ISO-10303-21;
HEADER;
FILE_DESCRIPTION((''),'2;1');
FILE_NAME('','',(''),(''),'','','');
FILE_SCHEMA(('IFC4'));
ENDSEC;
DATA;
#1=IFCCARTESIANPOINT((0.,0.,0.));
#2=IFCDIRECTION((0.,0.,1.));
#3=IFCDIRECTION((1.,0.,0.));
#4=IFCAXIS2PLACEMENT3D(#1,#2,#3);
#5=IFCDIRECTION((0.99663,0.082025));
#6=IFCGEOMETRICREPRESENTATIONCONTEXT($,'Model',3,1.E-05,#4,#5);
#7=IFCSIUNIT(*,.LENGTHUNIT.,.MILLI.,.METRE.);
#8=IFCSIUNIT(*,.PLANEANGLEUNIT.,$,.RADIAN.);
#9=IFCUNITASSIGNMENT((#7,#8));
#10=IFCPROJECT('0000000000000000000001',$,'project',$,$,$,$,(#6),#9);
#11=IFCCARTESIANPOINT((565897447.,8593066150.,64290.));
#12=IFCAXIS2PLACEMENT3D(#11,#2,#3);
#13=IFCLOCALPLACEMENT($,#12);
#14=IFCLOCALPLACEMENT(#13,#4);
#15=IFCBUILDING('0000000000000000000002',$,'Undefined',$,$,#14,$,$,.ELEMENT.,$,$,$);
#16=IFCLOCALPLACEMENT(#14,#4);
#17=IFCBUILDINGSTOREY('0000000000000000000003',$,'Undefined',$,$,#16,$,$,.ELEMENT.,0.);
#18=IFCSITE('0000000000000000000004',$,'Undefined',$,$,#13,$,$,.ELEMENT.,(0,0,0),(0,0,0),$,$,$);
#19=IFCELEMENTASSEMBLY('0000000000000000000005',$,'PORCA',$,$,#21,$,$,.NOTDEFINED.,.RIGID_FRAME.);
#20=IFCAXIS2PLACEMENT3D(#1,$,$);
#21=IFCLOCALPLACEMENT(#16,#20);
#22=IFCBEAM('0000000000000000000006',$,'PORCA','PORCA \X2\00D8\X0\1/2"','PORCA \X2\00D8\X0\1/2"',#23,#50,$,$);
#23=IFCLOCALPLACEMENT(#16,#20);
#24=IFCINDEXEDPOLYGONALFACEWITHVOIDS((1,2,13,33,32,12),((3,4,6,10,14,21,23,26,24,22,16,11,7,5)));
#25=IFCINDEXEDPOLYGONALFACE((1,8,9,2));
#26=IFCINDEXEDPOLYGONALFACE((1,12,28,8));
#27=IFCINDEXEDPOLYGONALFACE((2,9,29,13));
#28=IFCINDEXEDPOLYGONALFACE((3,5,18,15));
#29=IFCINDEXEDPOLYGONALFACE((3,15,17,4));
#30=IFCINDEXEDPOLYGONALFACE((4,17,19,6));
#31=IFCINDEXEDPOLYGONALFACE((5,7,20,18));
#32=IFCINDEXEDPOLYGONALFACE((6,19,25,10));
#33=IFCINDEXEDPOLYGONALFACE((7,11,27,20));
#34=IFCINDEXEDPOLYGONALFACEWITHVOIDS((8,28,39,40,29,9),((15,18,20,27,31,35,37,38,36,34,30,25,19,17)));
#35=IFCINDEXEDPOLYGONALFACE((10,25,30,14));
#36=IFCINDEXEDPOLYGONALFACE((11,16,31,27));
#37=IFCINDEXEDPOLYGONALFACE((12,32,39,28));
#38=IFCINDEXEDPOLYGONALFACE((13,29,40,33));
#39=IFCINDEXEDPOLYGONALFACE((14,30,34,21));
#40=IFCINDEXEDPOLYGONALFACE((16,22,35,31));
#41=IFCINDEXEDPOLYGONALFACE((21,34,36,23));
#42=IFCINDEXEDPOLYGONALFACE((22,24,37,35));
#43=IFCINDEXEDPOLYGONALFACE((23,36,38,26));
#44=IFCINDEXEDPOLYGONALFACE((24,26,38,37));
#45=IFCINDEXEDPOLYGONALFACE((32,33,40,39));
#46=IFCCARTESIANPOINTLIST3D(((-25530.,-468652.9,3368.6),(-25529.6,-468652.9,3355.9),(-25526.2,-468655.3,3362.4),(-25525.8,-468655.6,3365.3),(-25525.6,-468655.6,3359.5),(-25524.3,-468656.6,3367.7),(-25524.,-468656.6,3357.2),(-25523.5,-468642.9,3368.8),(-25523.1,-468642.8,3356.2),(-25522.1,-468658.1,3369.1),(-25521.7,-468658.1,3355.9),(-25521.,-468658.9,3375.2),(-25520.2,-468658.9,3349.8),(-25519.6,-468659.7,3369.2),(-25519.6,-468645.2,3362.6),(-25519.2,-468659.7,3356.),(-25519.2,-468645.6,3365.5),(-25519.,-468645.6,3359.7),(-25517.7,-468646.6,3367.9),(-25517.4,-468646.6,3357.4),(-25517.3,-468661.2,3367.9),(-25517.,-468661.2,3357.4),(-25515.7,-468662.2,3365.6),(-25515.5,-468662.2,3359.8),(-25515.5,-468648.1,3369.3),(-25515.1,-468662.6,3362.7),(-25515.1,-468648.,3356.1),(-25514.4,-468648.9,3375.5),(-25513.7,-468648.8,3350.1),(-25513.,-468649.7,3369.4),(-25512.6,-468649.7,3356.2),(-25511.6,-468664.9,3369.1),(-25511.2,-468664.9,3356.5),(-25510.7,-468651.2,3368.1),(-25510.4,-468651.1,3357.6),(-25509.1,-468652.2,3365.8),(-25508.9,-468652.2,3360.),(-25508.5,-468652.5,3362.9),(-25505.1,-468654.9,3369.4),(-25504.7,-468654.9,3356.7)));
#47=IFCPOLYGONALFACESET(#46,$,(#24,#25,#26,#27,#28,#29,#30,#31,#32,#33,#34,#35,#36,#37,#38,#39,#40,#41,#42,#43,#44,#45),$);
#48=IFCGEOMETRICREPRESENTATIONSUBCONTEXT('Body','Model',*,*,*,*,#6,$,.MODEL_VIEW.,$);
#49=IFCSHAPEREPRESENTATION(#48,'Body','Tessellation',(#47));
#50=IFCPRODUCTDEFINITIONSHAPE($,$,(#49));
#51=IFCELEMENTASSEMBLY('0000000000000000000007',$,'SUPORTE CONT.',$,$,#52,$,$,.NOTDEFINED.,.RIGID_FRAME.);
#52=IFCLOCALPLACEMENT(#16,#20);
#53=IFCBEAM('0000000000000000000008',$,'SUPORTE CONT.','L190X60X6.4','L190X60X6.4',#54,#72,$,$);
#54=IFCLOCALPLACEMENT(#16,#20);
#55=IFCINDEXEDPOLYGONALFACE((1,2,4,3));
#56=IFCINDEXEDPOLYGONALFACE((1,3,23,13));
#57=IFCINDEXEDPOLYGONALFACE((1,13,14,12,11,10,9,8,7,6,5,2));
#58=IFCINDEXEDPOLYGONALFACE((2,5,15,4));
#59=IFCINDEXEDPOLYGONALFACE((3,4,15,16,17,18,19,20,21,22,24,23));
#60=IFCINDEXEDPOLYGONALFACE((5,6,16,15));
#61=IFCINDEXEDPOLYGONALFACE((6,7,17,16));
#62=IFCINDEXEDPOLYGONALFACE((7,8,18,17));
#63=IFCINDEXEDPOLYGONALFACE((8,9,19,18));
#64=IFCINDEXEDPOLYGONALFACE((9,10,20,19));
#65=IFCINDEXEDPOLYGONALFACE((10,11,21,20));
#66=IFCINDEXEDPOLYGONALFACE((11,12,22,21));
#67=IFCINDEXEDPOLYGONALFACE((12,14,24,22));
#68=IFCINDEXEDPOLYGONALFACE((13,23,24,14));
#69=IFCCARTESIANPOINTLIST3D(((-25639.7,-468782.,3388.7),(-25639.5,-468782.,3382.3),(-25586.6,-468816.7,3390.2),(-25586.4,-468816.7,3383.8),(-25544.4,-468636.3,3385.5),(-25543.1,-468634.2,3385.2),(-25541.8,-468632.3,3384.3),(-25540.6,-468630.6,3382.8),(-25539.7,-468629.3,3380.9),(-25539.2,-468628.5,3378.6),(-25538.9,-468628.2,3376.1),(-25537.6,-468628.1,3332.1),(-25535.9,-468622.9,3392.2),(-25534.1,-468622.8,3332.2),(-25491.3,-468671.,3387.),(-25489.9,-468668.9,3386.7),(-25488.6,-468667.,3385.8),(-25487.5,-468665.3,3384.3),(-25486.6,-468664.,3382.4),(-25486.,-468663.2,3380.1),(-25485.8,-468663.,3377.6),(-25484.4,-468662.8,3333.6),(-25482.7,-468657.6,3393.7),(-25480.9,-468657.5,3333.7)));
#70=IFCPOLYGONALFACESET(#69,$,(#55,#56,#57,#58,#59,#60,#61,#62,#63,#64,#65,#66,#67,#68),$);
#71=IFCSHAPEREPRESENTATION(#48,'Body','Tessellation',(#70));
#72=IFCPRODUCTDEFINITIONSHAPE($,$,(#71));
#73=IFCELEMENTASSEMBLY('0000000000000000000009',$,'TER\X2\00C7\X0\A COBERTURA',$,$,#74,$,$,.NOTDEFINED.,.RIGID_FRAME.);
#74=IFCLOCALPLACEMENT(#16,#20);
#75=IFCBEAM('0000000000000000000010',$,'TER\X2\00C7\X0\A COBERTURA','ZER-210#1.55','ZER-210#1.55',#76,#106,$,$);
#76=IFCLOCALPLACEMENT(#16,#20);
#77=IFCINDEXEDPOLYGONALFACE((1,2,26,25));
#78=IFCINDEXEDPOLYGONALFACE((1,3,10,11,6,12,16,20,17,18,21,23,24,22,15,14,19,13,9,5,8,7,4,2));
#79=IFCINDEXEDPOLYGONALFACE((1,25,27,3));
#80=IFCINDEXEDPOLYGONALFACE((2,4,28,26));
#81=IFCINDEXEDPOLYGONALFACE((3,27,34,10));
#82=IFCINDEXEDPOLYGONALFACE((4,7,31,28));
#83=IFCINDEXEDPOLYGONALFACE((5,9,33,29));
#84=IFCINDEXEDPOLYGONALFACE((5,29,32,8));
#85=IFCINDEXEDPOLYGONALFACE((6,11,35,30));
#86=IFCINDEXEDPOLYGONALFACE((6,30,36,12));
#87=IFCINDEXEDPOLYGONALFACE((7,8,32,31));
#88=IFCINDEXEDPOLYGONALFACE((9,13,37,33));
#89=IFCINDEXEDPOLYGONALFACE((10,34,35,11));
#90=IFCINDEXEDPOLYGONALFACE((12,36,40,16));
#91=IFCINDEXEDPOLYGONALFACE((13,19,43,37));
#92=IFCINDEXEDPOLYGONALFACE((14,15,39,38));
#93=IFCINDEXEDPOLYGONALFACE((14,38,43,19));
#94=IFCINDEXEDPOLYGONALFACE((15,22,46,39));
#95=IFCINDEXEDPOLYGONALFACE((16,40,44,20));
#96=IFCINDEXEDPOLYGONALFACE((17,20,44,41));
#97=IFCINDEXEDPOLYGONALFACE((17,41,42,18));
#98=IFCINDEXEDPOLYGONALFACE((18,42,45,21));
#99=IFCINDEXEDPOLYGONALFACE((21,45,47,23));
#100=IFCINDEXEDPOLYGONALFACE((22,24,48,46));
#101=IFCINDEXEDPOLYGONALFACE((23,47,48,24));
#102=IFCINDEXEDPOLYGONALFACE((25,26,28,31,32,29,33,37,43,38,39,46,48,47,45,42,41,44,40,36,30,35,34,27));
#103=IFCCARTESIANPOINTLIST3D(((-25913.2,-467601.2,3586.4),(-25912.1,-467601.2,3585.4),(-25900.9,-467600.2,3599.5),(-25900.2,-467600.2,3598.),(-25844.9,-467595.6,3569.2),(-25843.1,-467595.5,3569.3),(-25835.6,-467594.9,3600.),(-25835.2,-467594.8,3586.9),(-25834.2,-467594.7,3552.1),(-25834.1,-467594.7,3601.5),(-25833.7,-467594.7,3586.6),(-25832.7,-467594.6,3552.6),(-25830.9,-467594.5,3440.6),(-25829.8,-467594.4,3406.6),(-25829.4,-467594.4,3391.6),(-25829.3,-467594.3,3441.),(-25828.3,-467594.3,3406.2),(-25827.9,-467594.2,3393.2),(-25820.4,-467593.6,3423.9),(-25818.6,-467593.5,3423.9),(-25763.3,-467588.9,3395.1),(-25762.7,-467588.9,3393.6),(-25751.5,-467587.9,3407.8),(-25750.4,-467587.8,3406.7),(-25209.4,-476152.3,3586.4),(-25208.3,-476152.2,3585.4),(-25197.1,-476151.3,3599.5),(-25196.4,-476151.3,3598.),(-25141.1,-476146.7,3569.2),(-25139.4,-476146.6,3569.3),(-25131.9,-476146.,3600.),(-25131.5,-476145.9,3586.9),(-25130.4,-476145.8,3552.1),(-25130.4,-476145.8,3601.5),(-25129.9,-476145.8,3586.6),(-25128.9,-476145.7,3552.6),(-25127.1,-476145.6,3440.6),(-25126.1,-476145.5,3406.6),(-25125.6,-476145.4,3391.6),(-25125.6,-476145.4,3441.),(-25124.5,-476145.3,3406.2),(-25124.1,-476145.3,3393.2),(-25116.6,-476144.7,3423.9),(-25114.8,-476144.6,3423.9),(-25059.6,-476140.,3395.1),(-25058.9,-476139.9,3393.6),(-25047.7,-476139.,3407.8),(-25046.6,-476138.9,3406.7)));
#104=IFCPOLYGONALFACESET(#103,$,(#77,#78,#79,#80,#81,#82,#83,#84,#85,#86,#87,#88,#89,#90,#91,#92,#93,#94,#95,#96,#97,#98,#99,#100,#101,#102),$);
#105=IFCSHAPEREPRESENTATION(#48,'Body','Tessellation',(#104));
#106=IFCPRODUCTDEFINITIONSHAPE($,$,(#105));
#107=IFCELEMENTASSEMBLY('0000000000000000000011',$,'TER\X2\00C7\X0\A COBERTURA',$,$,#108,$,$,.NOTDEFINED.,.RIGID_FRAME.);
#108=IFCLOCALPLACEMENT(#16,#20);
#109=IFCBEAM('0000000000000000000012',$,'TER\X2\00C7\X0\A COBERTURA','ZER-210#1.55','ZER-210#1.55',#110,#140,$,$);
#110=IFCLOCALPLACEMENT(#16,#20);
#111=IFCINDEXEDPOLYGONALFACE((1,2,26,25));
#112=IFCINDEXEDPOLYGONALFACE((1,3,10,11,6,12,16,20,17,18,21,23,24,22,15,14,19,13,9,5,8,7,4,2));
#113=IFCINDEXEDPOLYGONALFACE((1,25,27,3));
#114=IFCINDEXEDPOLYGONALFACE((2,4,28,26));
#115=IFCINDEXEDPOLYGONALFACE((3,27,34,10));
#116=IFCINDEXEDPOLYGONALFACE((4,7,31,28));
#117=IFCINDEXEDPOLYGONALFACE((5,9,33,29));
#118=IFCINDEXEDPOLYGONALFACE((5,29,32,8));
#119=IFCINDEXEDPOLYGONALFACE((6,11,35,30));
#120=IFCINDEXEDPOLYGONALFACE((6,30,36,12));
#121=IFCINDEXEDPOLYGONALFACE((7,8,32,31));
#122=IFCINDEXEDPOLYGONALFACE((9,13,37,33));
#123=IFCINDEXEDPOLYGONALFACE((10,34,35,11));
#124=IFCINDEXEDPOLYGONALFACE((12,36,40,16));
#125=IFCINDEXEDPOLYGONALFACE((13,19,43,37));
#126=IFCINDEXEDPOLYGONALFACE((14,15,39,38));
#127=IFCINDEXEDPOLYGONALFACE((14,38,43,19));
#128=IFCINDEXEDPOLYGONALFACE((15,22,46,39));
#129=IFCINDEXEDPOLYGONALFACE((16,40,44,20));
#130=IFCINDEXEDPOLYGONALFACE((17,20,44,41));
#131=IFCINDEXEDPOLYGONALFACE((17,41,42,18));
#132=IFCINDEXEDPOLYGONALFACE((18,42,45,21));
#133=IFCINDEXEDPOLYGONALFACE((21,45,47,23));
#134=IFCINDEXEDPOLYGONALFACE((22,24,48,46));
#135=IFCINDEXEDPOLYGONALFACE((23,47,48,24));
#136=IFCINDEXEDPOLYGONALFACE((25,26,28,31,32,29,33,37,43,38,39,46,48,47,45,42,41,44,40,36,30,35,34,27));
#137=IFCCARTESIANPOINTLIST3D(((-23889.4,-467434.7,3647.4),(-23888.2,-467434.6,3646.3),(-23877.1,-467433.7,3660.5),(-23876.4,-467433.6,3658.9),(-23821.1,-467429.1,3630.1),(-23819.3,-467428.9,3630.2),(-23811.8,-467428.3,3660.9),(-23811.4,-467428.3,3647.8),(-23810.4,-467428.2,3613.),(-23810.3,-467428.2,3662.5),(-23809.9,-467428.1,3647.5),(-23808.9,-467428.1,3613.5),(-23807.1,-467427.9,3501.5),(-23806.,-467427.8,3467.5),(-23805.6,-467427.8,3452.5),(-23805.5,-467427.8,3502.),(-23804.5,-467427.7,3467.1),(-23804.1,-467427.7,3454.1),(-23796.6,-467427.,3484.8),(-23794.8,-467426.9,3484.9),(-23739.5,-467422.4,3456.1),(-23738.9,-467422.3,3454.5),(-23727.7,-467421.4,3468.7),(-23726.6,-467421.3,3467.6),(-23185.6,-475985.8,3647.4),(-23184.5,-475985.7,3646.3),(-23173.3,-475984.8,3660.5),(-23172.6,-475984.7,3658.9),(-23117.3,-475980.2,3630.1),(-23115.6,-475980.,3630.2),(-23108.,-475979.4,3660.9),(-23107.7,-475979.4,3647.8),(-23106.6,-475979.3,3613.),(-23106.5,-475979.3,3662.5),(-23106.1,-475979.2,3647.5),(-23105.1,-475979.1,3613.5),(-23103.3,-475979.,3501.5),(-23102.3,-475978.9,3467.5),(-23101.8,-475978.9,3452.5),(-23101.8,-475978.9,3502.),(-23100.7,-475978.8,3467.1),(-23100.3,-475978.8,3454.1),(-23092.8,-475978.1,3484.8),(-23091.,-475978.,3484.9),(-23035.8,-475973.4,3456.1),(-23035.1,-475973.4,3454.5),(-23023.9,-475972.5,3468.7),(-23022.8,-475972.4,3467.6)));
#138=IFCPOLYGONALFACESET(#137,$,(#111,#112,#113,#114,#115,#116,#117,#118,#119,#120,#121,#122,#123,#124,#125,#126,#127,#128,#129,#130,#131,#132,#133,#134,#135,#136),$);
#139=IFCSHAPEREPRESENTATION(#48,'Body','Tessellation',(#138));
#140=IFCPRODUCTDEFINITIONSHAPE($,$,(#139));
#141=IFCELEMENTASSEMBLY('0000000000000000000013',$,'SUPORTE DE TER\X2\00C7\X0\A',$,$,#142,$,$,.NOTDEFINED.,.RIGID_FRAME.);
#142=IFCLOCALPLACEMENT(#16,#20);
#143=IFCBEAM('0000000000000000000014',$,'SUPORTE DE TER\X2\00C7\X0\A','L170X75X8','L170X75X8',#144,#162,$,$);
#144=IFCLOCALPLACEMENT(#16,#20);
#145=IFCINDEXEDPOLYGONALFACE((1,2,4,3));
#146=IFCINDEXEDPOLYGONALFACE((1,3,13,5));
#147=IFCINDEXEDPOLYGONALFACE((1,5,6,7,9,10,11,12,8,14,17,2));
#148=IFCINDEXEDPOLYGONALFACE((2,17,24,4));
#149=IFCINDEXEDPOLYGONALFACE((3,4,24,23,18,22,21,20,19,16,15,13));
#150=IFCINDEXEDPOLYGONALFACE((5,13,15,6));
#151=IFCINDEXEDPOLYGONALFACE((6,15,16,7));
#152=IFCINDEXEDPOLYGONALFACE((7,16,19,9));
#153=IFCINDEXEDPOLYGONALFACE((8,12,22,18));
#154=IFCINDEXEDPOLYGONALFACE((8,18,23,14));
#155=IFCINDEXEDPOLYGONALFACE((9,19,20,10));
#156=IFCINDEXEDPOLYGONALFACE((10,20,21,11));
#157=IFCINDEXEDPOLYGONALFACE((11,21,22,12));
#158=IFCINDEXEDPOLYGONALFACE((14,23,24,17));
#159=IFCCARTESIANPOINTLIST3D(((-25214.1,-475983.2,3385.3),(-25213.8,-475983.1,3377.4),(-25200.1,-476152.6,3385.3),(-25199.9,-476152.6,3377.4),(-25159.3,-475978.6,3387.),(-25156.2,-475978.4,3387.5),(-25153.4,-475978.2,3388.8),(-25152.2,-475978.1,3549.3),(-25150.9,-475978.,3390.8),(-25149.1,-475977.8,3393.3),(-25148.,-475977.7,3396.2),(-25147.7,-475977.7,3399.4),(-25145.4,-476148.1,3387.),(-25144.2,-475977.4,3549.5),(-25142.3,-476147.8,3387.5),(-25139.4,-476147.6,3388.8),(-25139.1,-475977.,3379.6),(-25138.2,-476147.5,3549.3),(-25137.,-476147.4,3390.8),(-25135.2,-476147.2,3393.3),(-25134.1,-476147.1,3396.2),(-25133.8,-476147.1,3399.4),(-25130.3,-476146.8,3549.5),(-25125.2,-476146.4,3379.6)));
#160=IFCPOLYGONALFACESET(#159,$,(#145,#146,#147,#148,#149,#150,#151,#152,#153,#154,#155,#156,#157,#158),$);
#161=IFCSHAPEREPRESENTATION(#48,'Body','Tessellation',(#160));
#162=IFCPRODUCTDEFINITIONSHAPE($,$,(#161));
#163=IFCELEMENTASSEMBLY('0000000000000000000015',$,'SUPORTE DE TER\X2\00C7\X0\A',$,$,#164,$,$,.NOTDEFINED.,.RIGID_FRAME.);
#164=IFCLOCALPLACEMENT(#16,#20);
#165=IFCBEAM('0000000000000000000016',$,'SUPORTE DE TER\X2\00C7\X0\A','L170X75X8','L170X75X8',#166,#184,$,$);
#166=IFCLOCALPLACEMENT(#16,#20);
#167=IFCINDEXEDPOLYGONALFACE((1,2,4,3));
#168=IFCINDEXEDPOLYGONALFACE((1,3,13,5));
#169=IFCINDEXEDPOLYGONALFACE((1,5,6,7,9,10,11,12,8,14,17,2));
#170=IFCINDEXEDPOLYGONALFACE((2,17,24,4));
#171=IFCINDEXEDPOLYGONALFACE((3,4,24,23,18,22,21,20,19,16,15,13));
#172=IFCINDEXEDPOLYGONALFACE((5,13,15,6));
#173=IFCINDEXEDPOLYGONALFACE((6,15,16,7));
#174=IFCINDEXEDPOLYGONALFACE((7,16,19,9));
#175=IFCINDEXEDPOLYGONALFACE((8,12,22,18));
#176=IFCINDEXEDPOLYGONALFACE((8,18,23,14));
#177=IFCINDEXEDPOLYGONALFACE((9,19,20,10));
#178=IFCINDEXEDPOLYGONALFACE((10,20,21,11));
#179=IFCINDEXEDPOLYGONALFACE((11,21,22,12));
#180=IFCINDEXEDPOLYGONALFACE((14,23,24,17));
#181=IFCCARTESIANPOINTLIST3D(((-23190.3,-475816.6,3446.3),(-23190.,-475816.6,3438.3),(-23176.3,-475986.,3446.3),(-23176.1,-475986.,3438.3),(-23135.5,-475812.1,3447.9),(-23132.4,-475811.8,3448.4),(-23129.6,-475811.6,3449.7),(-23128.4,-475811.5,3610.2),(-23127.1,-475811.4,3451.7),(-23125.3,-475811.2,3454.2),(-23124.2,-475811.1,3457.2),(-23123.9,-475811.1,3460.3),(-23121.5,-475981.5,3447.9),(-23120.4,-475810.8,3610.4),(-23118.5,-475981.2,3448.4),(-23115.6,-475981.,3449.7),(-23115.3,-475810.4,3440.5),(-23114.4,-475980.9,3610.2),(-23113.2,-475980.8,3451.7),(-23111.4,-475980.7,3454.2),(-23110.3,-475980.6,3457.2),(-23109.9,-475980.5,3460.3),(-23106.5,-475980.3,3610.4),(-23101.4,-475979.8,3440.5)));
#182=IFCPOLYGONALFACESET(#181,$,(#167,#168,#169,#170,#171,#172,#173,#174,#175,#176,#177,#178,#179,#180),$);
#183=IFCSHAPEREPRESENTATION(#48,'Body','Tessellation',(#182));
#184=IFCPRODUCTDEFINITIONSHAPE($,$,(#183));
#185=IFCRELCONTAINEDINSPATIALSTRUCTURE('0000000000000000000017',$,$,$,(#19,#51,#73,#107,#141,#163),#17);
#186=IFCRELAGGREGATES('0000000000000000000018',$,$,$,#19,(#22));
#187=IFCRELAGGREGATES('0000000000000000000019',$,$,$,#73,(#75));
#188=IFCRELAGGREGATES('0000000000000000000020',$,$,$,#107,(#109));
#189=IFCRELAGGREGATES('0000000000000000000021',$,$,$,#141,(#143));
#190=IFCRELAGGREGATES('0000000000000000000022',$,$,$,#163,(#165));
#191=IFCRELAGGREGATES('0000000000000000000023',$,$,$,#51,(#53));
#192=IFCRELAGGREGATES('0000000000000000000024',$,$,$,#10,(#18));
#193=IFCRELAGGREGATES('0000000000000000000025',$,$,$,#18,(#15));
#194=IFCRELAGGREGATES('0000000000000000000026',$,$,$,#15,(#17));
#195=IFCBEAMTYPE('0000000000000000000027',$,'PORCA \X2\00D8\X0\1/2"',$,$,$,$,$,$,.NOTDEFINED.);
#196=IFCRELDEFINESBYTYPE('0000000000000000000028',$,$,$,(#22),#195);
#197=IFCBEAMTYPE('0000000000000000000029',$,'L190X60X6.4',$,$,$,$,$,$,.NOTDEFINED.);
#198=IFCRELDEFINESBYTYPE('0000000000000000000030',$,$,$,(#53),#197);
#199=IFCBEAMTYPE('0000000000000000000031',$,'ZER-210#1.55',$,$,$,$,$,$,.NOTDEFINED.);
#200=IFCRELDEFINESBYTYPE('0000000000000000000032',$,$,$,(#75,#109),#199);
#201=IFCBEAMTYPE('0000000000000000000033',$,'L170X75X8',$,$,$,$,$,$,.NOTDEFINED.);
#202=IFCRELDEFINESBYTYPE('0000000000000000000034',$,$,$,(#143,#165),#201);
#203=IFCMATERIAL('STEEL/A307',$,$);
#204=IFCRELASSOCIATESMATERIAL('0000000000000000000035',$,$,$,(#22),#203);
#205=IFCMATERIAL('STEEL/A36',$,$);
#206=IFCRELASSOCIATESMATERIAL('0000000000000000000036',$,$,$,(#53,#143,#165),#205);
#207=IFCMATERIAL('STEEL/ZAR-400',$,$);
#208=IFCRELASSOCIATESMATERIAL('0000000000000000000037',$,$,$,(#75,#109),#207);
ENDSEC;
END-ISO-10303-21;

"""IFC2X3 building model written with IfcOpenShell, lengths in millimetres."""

from ifc_helpers import new_model, si_unit, direction, frame, origin_with_axes, origin_2d_with_axis, place, context, subcontext, project, spatial, polyline, l_section, outline, extrude, material, type_object, element, aggregate, save


model = new_model("IFC2X3")

# Units and contexts
model_context = context("Model", 3, precision=1e-05, world=origin_with_axes(), true_north=direction((0.99663, 0.082025)))
body_context = subcontext(model_context, "Body", "Model", "MODEL_VIEW")
ifc_project = project(units=[si_unit("LENGTHUNIT", "METRE", prefix="MILLI"), si_unit("PLANEANGLEUNIT", "RADIAN")], contexts=[model_context])

# Site, building, storey
site_placement = place(None, frame((565897447.0, 8593066150.0, 64290.0), z_axis=(0.0, 0.0, 1.0), x_axis=(1.0, 0.0, 0.0)))
site = spatial("IfcSite", under=ifc_project, at=site_placement, Name="Undefined", CompositionType="ELEMENT", RefLatitude=(0, 0, 0), RefLongitude=(0, 0, 0))
building_placement = place(site_placement, origin_with_axes())
building = spatial("IfcBuilding", under=site, at=building_placement, Name="Undefined", CompositionType="ELEMENT")
storey_placement = place(building_placement, origin_with_axes())
storey = spatial("IfcBuildingStorey", under=building, at=storey_placement, Name="Undefined", CompositionType="ELEMENT", Elevation=0.0)

# Element assemblies, beams
ifc_material_1 = material(Name="STEEL/ZAR-400")
ifc_material_2 = material(Name="STEEL/A36")
ifc_material_3 = material(Name="STEEL/A307")
assembly_1_placement = place(storey_placement, origin_with_axes())
assembly_1 = element("IfcElementAssembly", 1, at=assembly_1_placement, inside=storey, Name="PORCA", AssemblyPlace="NOTDEFINED", PredefinedType="RIGID_FRAME")
beam_type_1 = type_object("IfcBeamType", Name="PORCA Ø1/2\"", PredefinedType="NOTDEFINED")
beam_1_placement = place(assembly_1_placement, frame((-25520.6, -468658.9, 3362.5), z_axis=(0.836984, -0.546715, 0.02368), x_axis=(0.546411, 0.837315, 0.018398)))
beam_1 = element("IfcBeam", 2, at=beam_1_placement, type_object=beam_type_1, material=ifc_material_3, Name="PORCA", Description="PORCA Ø1/2\"", ObjectType="PORCA Ø1/2\"", context=body_context, shape_type="SweptSolid", body=[
    extrude(outline(polyline([(-6.3, -11.0), (-12.7, 0.0), (-6.3, 11.0), (6.3, 11.0), (12.7, 0.0), (6.3, -11.0), (-6.3, -11.0)]), holes=[polyline([(5.3, 4.2), (2.9, 6.0), (0.0, 6.7), (-2.9, 6.0), (-5.3, 4.2), (-6.6, 1.5), (-6.6, -1.5), (-5.3, -4.2), (-2.9, -6.0), (0.0, -6.7), (2.9, -6.0), (5.3, -4.2), (6.6, -1.5), (6.6, 1.5), (5.3, 4.2)])]), frame((12.0, 0.0, 0.0), z_axis=(-1.0, 0.0, 0.0), x_axis=(0.0, -1.0, 0.0)), (0.0, 0.0, 1.0), 12.0),
])
aggregate(assembly_1, [beam_1])
assembly_2_placement = place(storey_placement, origin_with_axes())
assembly_2 = element("IfcElementAssembly", 3, at=assembly_2_placement, inside=storey, Name="SUPORTE CONT.", AssemblyPlace="NOTDEFINED", PredefinedType="RIGID_FRAME")
beam_type_2 = type_object("IfcBeamType", Name="L190X60X6.4", PredefinedType="NOTDEFINED")
beam_2_placement = place(assembly_2_placement, frame((-25586.9, -468702.4, 3360.5), z_axis=(-0.546411, -0.837315, -0.018398), x_axis=(0.836984, -0.546715, 0.02368)))
beam_2 = element("IfcBeam", 4, at=beam_2_placement, type_object=beam_type_2, material=ifc_material_2, Name="SUPORTE CONT.", Description="L190X60X6.4", ObjectType="L190X60X6.4", context=body_context, shape_type="SweptSolid", body=[
    extrude(l_section(Depth=190.0, Width=60.0, Thickness=6.4, FilletRadius=9.6, at=origin_2d_with_axis()), frame((63.5, 0.0, 0.0), z_axis=(-1.0, 0.0, 0.0), x_axis=(0.0, -1.0, 0.0)), (0.0, 0.0, 1.0), 63.5),
])
assembly_3_placement = place(storey_placement, origin_with_axes())
assembly_3 = element("IfcElementAssembly", 5, at=assembly_3_placement, inside=storey, Name="TERÇA COBERTURA", AssemblyPlace="NOTDEFINED", PredefinedType="RIGID_FRAME")
beam_type_3 = type_object("IfcBeamType", Name="ZER-210#1.55", PredefinedType="NOTDEFINED")
beam_3_placement = place(assembly_3_placement, frame((-25128.0, -476145.6, 3496.6), z_axis=(-0.029885, -0.00246, 0.99955), x_axis=(-0.082025, 0.99663, 0.0)))
beam_3 = element("IfcBeam", 6, at=beam_3_placement, type_object=beam_type_3, material=ifc_material_1, Name="TERÇA COBERTURA", Description="ZER-210#1.55", ObjectType="ZER-210#1.55", context=body_context, shape_type="SweptSolid", body=[
    extrude(outline(polyline([(-65.6, 103.4), (-77.9, 91.2), (-79.0, 92.3), (-66.2, 105.0), (0.8, 105.0), (0.8, 90.0), (-9.2, 73.0), (0.8, 56.0), (0.8, -55.6), (11.0, -73.0), (0.8, -90.4), (0.8, -103.5), (65.6, -103.4), (77.9, -91.2), (79.0, -92.3), (66.2, -105.0), (-0.8, -105.0), (-0.8, -90.0), (9.2, -73.0), (-0.8, -56.0), (-0.8, 55.6), (-11.0, 73.0), (-0.8, 90.4), (-0.8, 103.5), (-65.6, 103.4)])), frame((8580.0, 0.0, 0.0), z_axis=(-1.0, 0.0, 0.0), x_axis=(0.0, -1.0, 0.0)), (0.0, 0.0, 1.0), 8580.0),
])
aggregate(assembly_3, [beam_3])
assembly_4_placement = place(storey_placement, origin_with_axes())
assembly_4 = element("IfcElementAssembly", 7, at=assembly_4_placement, inside=storey, Name="TERÇA COBERTURA", AssemblyPlace="NOTDEFINED", PredefinedType="RIGID_FRAME")
beam_4_placement = place(assembly_4_placement, frame((-23104.2, -475979.1, 3557.5), z_axis=(-0.029885, -0.00246, 0.99955), x_axis=(-0.082025, 0.99663, 0.0)))
beam_4 = element("IfcBeam", 8, at=beam_4_placement, type_object=beam_type_3, material=ifc_material_1, Name="TERÇA COBERTURA", Description="ZER-210#1.55", ObjectType="ZER-210#1.55", context=body_context, shape_type="SweptSolid", body=[
    extrude(outline(polyline([(-65.6, 103.4), (-77.9, 91.2), (-79.0, 92.3), (-66.2, 105.0), (0.8, 105.0), (0.8, 90.0), (-9.2, 73.0), (0.8, 56.0), (0.8, -55.6), (11.0, -73.0), (0.8, -90.4), (0.8, -103.5), (65.6, -103.4), (77.9, -91.2), (79.0, -92.3), (66.2, -105.0), (-0.8, -105.0), (-0.8, -90.0), (9.2, -73.0), (-0.8, -56.0), (-0.8, 55.6), (-11.0, 73.0), (-0.8, 90.4), (-0.8, 103.5), (-65.6, 103.4)])), frame((8580.0, 0.0, 0.0), z_axis=(-1.0, 0.0, 0.0), x_axis=(0.0, -1.0, 0.0)), (0.0, 0.0, 1.0), 8580.0),
])
aggregate(assembly_4, [beam_4])
assembly_5_placement = place(storey_placement, origin_with_axes())
assembly_5 = element("IfcElementAssembly", 9, at=assembly_5_placement, inside=storey, Name="SUPORTE DE TERÇA", AssemblyPlace="NOTDEFINED", PredefinedType="RIGID_FRAME")
beam_type_4 = type_object("IfcBeamType", Name="L170X75X8", PredefinedType="NOTDEFINED")
beam_5_placement = place(assembly_5_placement, frame((-25179.0, -475980.3, 3463.4), z_axis=(-0.029885, -0.00246, 0.99955), x_axis=(0.082025, -0.99663, 0.0)))
beam_5 = element("IfcBeam", 10, at=beam_5_placement, type_object=beam_type_4, material=ifc_material_2, Name="SUPORTE DE TERÇA", Description="L170X75X8", ObjectType="L170X75X8", context=body_context, shape_type="SweptSolid", body=[
    extrude(l_section(Depth=170.0, Width=75.0, Thickness=8.0, FilletRadius=12.0, at=origin_2d_with_axis()), frame((170.0, 0.0, 0.0), z_axis=(-1.0, 0.0, 0.0), x_axis=(0.0, -1.0, 0.0)), (0.0, 0.0, 1.0), 170.0),
])
aggregate(assembly_5, [beam_5])
assembly_6_placement = place(storey_placement, origin_with_axes())
assembly_6 = element("IfcElementAssembly", 11, at=assembly_6_placement, inside=storey, Name="SUPORTE DE TERÇA", AssemblyPlace="NOTDEFINED", PredefinedType="RIGID_FRAME")
beam_6_placement = place(assembly_6_placement, frame((-23155.2, -475813.7, 3524.4), z_axis=(-0.029885, -0.00246, 0.99955), x_axis=(0.082025, -0.99663, 0.0)))
beam_6 = element("IfcBeam", 12, at=beam_6_placement, type_object=beam_type_4, material=ifc_material_2, Name="SUPORTE DE TERÇA", Description="L170X75X8", ObjectType="L170X75X8", context=body_context, shape_type="SweptSolid", body=[
    extrude(l_section(Depth=170.0, Width=75.0, Thickness=8.0, FilletRadius=12.0, at=origin_2d_with_axis()), frame((170.0, 0.0, 0.0), z_axis=(-1.0, 0.0, 0.0), x_axis=(0.0, -1.0, 0.0)), (0.0, 0.0, 1.0), 170.0),
])
aggregate(assembly_6, [beam_6])

aggregate(assembly_2, [beam_2])

save(model, "model.ifc")
